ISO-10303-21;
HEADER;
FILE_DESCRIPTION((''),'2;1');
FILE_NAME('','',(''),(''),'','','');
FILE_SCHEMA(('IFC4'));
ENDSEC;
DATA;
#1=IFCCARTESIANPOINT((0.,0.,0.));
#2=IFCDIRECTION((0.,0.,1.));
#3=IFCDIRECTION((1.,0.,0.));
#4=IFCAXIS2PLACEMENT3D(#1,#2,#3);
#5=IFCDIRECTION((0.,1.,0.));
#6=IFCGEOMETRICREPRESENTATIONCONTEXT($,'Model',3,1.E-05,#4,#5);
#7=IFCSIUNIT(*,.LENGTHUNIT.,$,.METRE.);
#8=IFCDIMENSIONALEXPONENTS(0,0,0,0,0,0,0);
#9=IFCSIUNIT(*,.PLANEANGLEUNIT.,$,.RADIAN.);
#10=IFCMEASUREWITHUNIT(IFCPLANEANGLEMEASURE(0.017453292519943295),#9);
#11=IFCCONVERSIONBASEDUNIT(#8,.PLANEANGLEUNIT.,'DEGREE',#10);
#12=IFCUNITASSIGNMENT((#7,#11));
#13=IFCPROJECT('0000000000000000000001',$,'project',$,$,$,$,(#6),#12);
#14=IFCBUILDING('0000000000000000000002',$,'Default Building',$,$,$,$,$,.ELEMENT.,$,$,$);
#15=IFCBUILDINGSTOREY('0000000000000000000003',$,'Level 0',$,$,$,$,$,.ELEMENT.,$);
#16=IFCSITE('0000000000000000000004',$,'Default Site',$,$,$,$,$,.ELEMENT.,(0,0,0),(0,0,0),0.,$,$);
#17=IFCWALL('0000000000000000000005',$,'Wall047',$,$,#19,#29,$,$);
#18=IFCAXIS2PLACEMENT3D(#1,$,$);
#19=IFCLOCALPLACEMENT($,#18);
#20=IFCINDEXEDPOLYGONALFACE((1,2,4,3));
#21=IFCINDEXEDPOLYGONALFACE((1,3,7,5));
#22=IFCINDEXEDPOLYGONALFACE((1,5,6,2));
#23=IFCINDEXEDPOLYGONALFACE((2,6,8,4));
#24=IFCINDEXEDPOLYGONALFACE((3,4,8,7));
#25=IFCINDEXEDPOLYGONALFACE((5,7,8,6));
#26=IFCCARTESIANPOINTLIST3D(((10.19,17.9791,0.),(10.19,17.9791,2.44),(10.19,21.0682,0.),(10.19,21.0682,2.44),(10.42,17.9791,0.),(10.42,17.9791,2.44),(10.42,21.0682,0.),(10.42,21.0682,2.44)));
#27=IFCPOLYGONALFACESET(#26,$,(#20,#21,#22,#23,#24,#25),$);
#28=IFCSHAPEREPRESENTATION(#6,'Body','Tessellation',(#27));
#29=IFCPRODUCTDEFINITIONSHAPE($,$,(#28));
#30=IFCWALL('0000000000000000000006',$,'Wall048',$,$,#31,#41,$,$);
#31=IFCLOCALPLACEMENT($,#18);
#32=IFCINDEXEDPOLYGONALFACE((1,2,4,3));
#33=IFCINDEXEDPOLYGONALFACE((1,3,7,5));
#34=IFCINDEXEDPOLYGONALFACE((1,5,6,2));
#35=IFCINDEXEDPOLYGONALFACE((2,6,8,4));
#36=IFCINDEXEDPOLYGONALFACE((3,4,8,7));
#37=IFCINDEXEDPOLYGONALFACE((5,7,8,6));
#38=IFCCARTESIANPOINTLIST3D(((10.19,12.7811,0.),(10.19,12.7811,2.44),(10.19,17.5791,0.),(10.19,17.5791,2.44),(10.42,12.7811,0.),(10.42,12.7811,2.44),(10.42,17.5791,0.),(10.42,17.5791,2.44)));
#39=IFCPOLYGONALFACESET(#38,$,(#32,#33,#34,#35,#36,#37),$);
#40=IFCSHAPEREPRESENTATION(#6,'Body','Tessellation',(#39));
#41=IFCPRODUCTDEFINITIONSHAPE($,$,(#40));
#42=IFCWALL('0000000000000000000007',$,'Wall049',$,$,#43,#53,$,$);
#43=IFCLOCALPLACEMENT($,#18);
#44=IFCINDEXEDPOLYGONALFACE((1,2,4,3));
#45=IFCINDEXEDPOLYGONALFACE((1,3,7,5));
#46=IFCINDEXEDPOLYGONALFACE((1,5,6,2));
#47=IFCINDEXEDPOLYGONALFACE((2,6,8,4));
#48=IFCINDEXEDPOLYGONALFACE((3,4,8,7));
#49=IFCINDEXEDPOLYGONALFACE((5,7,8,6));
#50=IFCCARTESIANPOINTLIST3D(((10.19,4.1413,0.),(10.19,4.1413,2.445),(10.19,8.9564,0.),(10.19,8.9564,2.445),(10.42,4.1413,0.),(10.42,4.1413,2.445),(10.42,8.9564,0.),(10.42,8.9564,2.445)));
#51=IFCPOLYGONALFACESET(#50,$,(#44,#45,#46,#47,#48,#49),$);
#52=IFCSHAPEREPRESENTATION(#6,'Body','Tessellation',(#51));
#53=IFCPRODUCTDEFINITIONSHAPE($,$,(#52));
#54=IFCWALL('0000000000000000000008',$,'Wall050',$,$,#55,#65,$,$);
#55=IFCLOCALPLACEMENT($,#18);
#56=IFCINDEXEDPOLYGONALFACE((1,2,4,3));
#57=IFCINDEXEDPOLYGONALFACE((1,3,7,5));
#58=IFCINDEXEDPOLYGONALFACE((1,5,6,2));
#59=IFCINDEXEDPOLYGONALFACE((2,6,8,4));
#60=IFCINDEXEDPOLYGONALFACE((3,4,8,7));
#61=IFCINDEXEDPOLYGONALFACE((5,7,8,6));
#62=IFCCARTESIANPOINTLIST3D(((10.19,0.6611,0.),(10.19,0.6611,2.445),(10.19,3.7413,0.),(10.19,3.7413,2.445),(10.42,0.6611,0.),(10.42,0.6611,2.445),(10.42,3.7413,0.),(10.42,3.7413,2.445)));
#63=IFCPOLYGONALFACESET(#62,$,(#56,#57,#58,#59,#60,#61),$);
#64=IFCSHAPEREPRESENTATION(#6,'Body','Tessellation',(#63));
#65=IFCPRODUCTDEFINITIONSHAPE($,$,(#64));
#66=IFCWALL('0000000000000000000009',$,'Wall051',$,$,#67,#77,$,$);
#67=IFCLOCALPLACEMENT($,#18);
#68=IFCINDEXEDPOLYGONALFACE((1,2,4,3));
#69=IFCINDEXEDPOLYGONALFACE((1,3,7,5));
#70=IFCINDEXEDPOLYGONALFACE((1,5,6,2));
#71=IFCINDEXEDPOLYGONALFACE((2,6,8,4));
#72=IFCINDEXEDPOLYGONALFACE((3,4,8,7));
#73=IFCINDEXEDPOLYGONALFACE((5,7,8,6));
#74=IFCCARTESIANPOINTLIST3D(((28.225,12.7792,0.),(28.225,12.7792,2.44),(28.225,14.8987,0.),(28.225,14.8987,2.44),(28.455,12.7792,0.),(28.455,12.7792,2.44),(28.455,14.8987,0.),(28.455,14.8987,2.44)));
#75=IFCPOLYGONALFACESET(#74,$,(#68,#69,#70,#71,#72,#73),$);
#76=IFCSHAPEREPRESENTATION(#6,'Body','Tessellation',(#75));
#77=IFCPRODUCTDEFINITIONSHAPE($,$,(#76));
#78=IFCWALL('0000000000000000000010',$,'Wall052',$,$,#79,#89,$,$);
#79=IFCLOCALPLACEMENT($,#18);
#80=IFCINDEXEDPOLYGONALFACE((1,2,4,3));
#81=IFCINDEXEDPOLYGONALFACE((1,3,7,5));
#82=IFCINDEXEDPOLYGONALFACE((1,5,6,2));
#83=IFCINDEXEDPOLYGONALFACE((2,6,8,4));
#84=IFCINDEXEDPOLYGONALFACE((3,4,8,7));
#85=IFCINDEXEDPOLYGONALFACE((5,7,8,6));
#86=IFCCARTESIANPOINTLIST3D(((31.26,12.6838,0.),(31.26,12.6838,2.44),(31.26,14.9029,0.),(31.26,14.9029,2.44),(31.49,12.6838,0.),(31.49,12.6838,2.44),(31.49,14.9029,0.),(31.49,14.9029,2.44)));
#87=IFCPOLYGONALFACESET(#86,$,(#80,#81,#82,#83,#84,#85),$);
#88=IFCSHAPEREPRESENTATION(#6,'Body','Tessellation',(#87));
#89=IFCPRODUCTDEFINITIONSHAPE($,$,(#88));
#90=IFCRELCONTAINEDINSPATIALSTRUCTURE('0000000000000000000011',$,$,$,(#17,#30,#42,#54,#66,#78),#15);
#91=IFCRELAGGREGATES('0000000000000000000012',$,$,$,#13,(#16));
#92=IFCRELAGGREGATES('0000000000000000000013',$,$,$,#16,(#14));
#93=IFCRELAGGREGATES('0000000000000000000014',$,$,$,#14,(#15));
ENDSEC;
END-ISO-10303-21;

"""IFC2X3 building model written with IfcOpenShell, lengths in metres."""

from ifc_helpers import new_model, entity, si_unit, converted_unit, direction, frame, frame_2d, origin_with_axes, place, context, project, spatial, rectangle, extrude, element, save


model = new_model("IFC2X3")

# Units and contexts
model_context = context("Model", 3, precision=1e-05, world=origin_with_axes(), true_north=direction((0.0, 1.0, 0.0)))
ifc_project = project(units=[si_unit("LENGTHUNIT", "METRE"), converted_unit("PLANEANGLEUNIT", "DEGREE", entity("IfcPlaneAngleMeasure", 0.017453292519943295), si_unit("PLANEANGLEUNIT", "RADIAN"), dimensions=[0, 0, 0, 0, 0, 0, 0])], contexts=[model_context])

# Site, building, storey
site = spatial("IfcSite", under=ifc_project, Name="Default Site", CompositionType="ELEMENT", RefLatitude=(0, 0, 0), RefLongitude=(0, 0, 0), RefElevation=0.0)
building = spatial("IfcBuilding", under=site, Name="Default Building", CompositionType="ELEMENT")
storey = spatial("IfcBuildingStorey", under=building, Name="Level 0", CompositionType="ELEMENT")

# Shared definitions
placement = place(None, origin_with_axes())

# Walls
element("IfcWall", 1, at=placement, inside=storey, Name="Wall047", context=model_context, shape_type="SweptSolid", body=[
    extrude(rectangle(XDim=3.0891, YDim=0.23, at=frame_2d((0.0, 0.0), x_axis=(0.0, -1.0, 0.0))), frame((10.305, 19.5237, 0.0), z_axis=(0.0, 0.0, 1.0), x_axis=(1.0, 0.0, 0.0)), (0.0, 0.0, 1.0), 2.44),
])
element("IfcWall", 2, at=placement, inside=storey, Name="Wall048", context=model_context, shape_type="SweptSolid", body=[
    extrude(rectangle(XDim=4.798, YDim=0.23, at=frame_2d((0.0, 0.0), x_axis=(0.0, -1.0, 0.0))), frame((10.305, 15.1801, 0.0), z_axis=(0.0, 0.0, 1.0), x_axis=(1.0, 0.0, 0.0)), (0.0, 0.0, 1.0), 2.44),
])
element("IfcWall", 3, at=placement, inside=storey, Name="Wall049", context=model_context, shape_type="SweptSolid", body=[
    extrude(rectangle(XDim=4.8151, YDim=0.23, at=frame_2d((0.0, 0.0), x_axis=(0.0, -1.0, 0.0))), frame((10.305, 6.5488, 0.0), z_axis=(0.0, 0.0, 1.0), x_axis=(1.0, 0.0, 0.0)), (0.0, 0.0, 1.0), 2.445),
])
element("IfcWall", 4, at=placement, inside=storey, Name="Wall050", context=model_context, shape_type="SweptSolid", body=[
    extrude(rectangle(XDim=3.0802, YDim=0.23, at=frame_2d((0.0, 0.0), x_axis=(0.0, -1.0, 0.0))), frame((10.305, 2.2012, 0.0), z_axis=(0.0, 0.0, 1.0), x_axis=(1.0, 0.0, 0.0)), (0.0, 0.0, 1.0), 2.445),
])
element("IfcWall", 5, at=placement, inside=storey, Name="Wall051", context=model_context, shape_type="SweptSolid", body=[
    extrude(rectangle(XDim=2.1195, YDim=0.23, at=frame_2d((0.0, 0.0), x_axis=(0.0, -1.0, 0.0))), frame((28.34, 13.8389, 0.0), z_axis=(0.0, 0.0, 1.0), x_axis=(1.0, 0.0, 0.0)), (0.0, 0.0, 1.0), 2.44),
])
element("IfcWall", 6, at=placement, inside=storey, Name="Wall052", context=model_context, shape_type="SweptSolid", body=[
    extrude(rectangle(XDim=2.2191, YDim=0.23, at=frame_2d((0.0, 0.0), x_axis=(0.0, 1.0, 0.0))), frame((31.375, 13.7934, 0.0), z_axis=(0.0, 0.0, 1.0), x_axis=(1.0, 0.0, 0.0)), (0.0, 0.0, 1.0), 2.44),
])

save(model, "model.ifc")
